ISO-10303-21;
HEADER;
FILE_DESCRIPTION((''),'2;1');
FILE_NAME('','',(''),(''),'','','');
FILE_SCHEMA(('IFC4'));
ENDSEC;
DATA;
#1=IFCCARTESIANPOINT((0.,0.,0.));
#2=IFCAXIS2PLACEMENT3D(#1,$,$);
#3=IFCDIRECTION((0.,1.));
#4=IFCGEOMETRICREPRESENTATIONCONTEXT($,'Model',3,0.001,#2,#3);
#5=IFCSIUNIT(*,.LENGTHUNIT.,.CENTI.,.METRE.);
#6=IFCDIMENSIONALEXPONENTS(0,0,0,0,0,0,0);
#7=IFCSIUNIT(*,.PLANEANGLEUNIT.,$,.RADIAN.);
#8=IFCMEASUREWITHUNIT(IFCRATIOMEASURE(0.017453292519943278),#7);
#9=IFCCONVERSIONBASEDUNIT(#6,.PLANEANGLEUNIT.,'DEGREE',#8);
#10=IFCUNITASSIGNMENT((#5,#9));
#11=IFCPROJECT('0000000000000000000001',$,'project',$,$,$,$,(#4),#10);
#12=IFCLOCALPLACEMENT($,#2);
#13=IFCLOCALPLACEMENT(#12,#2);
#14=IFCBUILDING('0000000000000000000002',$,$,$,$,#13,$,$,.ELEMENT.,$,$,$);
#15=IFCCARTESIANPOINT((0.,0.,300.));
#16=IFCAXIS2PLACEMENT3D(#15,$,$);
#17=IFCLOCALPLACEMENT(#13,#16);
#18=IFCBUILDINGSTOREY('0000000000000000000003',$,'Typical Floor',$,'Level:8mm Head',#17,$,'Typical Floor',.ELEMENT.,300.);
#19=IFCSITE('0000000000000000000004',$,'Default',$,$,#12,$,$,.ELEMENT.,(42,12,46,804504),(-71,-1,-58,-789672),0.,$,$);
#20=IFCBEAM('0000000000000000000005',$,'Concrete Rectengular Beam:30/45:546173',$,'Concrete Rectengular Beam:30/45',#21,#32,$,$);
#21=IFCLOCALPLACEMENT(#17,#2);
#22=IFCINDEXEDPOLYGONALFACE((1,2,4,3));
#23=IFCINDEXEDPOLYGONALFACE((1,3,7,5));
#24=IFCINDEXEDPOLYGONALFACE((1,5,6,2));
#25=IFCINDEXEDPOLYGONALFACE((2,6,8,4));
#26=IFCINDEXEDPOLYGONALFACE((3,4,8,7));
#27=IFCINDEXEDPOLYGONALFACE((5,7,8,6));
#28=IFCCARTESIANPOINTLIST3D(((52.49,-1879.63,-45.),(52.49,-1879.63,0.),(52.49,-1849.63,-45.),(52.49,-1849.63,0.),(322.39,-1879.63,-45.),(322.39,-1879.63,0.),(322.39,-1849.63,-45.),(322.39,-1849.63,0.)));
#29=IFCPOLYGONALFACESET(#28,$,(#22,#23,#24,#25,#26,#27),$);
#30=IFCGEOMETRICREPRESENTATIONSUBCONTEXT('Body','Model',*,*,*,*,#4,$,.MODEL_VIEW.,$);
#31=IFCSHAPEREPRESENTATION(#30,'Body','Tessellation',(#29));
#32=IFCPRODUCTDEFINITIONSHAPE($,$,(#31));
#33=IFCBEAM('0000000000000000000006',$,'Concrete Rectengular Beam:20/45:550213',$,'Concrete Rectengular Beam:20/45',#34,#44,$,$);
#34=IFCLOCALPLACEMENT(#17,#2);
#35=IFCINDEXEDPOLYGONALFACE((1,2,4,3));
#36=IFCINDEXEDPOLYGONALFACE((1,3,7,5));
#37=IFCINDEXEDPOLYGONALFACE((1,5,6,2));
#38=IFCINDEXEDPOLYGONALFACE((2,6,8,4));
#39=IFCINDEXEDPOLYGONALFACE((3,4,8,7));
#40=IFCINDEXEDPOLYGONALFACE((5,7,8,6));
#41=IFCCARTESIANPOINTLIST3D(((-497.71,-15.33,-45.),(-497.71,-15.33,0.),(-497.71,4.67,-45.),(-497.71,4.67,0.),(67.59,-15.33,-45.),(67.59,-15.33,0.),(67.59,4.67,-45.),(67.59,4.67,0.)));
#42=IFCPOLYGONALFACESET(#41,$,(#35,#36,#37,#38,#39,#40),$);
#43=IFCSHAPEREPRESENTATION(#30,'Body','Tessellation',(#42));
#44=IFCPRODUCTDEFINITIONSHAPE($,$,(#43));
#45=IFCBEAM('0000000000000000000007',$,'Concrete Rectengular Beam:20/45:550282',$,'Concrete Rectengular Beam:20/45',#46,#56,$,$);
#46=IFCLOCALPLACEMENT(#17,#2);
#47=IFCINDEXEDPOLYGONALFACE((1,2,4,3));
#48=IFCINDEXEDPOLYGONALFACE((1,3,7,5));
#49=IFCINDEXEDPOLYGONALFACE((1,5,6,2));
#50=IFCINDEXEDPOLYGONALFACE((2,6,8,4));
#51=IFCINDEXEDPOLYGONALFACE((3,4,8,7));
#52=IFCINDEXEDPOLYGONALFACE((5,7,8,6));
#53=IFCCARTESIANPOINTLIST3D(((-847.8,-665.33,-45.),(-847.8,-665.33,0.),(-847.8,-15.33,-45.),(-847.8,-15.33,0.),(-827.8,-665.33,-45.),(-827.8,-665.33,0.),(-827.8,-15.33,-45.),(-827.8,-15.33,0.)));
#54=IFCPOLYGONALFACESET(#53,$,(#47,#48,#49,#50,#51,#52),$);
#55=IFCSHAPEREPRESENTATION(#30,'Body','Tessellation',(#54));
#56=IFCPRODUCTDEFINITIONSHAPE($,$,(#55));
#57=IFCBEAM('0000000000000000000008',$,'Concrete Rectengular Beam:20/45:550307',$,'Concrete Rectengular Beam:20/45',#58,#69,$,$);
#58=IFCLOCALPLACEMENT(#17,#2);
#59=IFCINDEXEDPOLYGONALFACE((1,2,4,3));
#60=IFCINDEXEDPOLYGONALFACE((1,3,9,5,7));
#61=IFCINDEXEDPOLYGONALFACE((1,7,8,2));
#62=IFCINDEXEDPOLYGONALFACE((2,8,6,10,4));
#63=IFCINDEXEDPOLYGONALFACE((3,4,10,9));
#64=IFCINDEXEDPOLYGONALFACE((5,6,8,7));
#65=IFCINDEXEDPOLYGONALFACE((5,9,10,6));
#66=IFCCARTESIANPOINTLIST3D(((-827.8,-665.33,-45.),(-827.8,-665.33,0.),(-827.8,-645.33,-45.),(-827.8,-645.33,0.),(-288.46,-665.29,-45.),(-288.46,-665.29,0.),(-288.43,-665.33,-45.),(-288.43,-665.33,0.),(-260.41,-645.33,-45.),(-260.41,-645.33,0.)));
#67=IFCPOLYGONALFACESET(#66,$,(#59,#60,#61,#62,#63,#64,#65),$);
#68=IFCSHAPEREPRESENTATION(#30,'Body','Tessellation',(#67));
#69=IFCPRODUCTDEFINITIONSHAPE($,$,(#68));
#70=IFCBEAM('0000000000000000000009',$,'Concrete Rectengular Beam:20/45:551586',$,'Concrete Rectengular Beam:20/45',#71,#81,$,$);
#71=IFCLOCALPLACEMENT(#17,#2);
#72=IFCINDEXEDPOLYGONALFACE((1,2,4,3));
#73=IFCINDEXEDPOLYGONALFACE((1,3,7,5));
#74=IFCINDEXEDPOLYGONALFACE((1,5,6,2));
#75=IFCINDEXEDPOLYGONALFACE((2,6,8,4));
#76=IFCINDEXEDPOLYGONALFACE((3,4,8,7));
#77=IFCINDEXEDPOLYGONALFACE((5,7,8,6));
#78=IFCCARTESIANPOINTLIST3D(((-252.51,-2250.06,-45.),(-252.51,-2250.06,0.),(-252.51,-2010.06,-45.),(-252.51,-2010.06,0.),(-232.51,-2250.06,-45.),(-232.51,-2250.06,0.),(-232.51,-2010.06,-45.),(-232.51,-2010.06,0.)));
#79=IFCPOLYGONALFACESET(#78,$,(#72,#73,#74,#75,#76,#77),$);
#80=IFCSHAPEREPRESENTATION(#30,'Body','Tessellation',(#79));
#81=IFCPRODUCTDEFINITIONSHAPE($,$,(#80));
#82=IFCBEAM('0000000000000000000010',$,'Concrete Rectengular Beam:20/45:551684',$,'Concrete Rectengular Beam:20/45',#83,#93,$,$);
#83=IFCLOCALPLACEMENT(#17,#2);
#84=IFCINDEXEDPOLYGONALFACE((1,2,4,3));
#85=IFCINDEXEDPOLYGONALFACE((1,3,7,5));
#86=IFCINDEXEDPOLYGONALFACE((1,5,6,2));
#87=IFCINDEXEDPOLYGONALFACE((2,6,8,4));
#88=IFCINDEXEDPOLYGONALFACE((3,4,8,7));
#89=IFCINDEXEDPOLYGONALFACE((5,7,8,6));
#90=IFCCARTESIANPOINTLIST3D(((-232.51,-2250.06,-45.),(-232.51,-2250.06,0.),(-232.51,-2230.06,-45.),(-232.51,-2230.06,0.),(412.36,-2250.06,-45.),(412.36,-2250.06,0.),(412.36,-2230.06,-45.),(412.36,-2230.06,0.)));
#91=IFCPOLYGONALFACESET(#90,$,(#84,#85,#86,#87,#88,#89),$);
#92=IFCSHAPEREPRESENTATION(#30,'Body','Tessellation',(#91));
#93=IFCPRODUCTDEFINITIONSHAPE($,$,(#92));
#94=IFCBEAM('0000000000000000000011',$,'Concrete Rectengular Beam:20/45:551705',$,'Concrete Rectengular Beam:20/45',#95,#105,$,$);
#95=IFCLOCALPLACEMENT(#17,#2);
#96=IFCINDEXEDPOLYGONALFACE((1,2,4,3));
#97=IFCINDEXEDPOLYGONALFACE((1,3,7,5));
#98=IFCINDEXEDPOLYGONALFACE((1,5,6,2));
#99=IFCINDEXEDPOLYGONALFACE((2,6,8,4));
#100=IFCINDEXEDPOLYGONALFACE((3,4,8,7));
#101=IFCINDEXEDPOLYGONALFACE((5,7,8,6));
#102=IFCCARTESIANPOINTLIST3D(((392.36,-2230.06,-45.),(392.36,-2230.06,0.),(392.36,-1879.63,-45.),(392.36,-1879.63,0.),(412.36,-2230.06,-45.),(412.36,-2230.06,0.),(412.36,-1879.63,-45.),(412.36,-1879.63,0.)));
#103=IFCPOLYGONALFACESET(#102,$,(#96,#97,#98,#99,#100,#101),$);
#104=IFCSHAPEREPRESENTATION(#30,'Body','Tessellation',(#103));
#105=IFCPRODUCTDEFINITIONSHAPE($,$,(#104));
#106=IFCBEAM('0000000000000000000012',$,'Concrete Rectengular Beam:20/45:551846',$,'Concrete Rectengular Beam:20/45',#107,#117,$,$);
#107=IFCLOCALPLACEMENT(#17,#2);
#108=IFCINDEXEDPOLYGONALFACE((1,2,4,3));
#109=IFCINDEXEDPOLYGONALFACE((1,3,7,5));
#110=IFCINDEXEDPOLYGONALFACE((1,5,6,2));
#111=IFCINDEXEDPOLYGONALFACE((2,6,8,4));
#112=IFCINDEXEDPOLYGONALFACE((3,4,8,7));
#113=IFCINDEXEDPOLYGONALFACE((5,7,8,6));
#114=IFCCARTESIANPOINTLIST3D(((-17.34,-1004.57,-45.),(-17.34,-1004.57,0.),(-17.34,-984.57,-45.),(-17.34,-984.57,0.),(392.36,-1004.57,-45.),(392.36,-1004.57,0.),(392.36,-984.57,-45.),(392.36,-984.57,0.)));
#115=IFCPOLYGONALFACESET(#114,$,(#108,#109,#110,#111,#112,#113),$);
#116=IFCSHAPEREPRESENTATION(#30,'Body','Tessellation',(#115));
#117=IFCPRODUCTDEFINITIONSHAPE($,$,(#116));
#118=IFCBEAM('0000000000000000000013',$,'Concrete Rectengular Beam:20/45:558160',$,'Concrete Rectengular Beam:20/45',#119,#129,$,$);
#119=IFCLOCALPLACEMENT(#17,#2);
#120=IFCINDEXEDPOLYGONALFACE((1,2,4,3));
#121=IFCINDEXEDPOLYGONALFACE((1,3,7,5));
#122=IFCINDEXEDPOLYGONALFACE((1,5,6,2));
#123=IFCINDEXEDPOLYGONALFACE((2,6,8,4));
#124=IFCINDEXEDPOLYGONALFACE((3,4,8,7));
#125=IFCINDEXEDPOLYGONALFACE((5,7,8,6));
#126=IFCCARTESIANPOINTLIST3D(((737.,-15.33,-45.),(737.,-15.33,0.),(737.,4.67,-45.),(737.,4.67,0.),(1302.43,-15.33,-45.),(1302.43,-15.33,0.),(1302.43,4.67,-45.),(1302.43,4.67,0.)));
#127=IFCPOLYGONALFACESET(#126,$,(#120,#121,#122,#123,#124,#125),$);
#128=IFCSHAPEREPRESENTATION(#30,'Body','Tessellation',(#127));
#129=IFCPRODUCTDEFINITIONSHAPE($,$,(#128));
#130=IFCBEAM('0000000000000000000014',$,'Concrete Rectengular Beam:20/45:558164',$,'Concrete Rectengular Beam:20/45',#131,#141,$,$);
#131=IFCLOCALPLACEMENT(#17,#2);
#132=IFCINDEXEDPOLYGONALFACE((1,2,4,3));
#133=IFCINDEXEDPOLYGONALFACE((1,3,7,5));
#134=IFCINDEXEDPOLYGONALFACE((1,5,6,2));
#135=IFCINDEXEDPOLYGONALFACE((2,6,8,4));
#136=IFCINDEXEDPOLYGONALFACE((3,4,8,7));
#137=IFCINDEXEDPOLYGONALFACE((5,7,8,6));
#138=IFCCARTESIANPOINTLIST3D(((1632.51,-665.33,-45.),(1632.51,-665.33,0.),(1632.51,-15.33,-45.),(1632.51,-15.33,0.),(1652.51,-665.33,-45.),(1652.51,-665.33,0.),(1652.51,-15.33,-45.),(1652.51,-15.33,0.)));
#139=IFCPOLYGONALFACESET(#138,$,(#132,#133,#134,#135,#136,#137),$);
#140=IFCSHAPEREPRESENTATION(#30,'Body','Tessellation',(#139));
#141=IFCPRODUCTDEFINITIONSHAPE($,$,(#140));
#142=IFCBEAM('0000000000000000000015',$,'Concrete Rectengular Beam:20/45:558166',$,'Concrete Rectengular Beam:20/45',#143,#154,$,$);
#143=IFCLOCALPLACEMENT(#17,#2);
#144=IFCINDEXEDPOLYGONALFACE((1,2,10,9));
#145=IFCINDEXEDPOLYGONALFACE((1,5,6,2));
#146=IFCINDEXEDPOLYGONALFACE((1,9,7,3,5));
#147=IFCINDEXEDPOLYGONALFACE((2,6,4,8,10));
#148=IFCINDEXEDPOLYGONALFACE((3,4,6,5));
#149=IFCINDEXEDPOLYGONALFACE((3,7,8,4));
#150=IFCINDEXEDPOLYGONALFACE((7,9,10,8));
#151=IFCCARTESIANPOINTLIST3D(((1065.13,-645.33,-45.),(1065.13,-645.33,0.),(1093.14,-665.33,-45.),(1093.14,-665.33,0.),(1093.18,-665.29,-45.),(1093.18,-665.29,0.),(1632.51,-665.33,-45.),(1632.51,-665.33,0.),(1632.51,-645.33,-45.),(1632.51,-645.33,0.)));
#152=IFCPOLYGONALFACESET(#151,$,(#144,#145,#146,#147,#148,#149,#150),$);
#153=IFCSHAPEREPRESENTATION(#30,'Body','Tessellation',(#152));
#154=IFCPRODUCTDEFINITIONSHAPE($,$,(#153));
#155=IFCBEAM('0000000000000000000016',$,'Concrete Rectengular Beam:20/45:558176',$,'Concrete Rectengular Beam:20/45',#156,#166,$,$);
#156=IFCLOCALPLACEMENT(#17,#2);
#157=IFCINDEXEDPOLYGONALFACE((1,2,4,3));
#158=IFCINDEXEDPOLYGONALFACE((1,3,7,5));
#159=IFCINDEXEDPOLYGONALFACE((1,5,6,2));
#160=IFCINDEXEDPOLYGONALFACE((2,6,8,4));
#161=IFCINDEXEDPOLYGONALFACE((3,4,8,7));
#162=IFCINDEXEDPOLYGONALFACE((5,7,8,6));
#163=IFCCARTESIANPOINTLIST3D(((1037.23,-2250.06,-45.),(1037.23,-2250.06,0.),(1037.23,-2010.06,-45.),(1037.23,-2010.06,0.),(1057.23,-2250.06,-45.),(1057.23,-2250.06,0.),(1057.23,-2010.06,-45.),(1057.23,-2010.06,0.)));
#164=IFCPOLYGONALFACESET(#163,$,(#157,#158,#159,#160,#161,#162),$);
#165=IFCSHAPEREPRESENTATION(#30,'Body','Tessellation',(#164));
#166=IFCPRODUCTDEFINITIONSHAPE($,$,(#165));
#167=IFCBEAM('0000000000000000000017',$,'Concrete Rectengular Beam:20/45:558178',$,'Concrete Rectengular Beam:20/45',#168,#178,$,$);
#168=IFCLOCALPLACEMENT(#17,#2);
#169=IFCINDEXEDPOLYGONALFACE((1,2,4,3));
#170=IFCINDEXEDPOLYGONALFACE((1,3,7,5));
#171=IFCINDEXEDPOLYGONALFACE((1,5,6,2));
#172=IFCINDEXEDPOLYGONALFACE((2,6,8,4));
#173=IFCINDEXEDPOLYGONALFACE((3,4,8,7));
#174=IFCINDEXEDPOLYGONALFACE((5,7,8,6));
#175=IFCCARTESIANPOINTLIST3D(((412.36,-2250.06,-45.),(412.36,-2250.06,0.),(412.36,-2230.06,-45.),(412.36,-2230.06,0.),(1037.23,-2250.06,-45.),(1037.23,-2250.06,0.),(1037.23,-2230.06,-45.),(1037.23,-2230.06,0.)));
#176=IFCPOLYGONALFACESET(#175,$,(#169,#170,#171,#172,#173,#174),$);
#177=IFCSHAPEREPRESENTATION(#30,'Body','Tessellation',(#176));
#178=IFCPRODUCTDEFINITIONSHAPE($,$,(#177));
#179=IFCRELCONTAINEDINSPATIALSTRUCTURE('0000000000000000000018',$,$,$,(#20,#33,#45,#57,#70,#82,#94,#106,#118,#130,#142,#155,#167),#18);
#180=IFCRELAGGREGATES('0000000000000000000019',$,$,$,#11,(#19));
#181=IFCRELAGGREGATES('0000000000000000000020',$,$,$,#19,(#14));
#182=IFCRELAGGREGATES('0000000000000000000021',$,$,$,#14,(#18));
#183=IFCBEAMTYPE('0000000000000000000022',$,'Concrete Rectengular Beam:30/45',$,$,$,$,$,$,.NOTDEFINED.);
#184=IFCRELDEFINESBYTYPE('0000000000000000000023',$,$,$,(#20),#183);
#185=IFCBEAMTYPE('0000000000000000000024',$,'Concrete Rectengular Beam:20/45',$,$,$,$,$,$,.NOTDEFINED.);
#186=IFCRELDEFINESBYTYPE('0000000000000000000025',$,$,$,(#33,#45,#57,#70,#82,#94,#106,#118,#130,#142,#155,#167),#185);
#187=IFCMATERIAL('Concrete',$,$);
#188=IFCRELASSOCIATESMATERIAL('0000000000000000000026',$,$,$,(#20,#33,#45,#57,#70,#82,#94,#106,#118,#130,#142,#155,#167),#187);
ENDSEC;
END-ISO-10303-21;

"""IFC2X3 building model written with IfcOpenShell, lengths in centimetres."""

from ifc_helpers import new_model, entity, si_unit, converted_unit, direction, frame, frame_2d, origin, place, context, subcontext, project, spatial, polyline, rectangle, extrude, clip, bounded_halfspace, material, type_object, element, save


model = new_model("IFC2X3")

# Units and contexts
model_context = context("Model", 3, precision=0.001, world=origin(), true_north=direction((0.0, 1.0)))
body_context = subcontext(model_context, "Body", "Model", "MODEL_VIEW")
ifc_project = project(units=[si_unit("LENGTHUNIT", "METRE", prefix="CENTI"), converted_unit("PLANEANGLEUNIT", "DEGREE", entity("IfcRatioMeasure", 0.017453292519943278), si_unit("PLANEANGLEUNIT", "RADIAN"), dimensions=[0, 0, 0, 0, 0, 0, 0])], contexts=[model_context])

# Site, building, storey
site_placement = place(None, origin())
site = spatial("IfcSite", under=ifc_project, at=site_placement, Name="Default", CompositionType="ELEMENT", RefLatitude=(42, 12, 46, 804504), RefLongitude=(-71, -1, -58, -789672), RefElevation=0.0)
building_placement = place(site_placement, origin())
building = spatial("IfcBuilding", under=site, at=building_placement, CompositionType="ELEMENT")
storey_placement = place(building_placement, frame((0.0, 0.0, 300.0)))
storey = spatial("IfcBuildingStorey", under=building, at=storey_placement, Name="Typical Floor", ObjectType="Level:8mm Head", LongName="Typical Floor", CompositionType="ELEMENT", Elevation=300.0)

# Beams
ifc_material = material(Name="Concrete")
beam_type_1 = type_object("IfcBeamType", Name="Concrete Rectengular Beam:30/45", PredefinedType="NOTDEFINED")
beam_1_placement = place(storey_placement, frame((322.39, -1864.63, 0.0), z_axis=(0.0, 0.0, 1.0), x_axis=(-1.0, 0.0, 0.0)))
element("IfcBeam", 1, at=beam_1_placement, inside=storey, type_object=beam_type_1, material=ifc_material, Name="Concrete Rectengular Beam:30/45:546173", ObjectType="Concrete Rectengular Beam:30/45", context=body_context, shape_type="SweptSolid", body=[
    extrude(rectangle(XDim=45.0, YDim=30.0, at=frame_2d((0.0, 0.0), x_axis=(1.0, 0.0))), frame((0.0, 0.0, -22.5), z_axis=(1.0, 0.0, 0.0), x_axis=(0.0, 0.0, -1.0)), (0.0, 0.0, 1.0), 269.9),
])
beam_type_2 = type_object("IfcBeamType", Name="Concrete Rectengular Beam:20/45", PredefinedType="NOTDEFINED")
beam_2_placement = place(storey_placement, frame((-507.71, -5.33, 0.0)))
element("IfcBeam", 2, at=beam_2_placement, inside=storey, type_object=beam_type_2, material=ifc_material, Name="Concrete Rectengular Beam:20/45:550213", ObjectType="Concrete Rectengular Beam:20/45", context=body_context, shape_type="SweptSolid", body=[
    extrude(rectangle(XDim=45.0, YDim=20.0, at=frame_2d((0.0, 0.0), x_axis=(1.0, 0.0))), frame((10.0, 0.0, -22.5), z_axis=(1.0, 0.0, 0.0), x_axis=(0.0, 0.0, -1.0)), (0.0, 0.0, 1.0), 565.3),
])
beam_3_placement = place(storey_placement, frame((-837.8, -5.33, 0.0), z_axis=(0.0, 0.0, 1.0), x_axis=(0.0, -1.0, 0.0)))
element("IfcBeam", 3, at=beam_3_placement, inside=storey, type_object=beam_type_2, material=ifc_material, Name="Concrete Rectengular Beam:20/45:550282", ObjectType="Concrete Rectengular Beam:20/45", context=body_context, shape_type="SweptSolid", body=[
    extrude(rectangle(XDim=45.0, YDim=20.0, at=frame_2d((0.0, 0.0), x_axis=(1.0, 0.0))), frame((10.0, 0.0, -22.5), z_axis=(1.0, 0.0, 0.0), x_axis=(0.0, 0.0, -1.0)), (0.0, 0.0, 1.0), 650.0),
])
beam_4_placement = place(storey_placement, frame((-837.8, -655.33, 0.0)))
element("IfcBeam", 4, at=beam_4_placement, inside=storey, type_object=beam_type_2, material=ifc_material, Name="Concrete Rectengular Beam:20/45:550307", ObjectType="Concrete Rectengular Beam:20/45", context=body_context, shape_type="SweptSolid", body=[
    clip(clip(extrude(rectangle(XDim=45.0, YDim=20.0, at=frame_2d((0.0, 0.0), x_axis=(1.0, 0.0))), frame((10.0, 0.0, -22.5), z_axis=(1.0, 0.0, 0.0), x_axis=(0.0, 0.0, -1.0)), (0.0, 0.0, 1.0), 567.38), bounded_halfspace(frame((577.9, 10.37, -300.0), z_axis=(0.579755, -0.814791, 0.0), x_axis=(-0.814791, -0.579755, 0.0)), False, frame((10.0, 0.0, -22.5), z_axis=(1.0, 0.0, 0.0), x_axis=(0.0, 0.0, -1.0)), polyline([(-22.5, -9.96), (22.5, -9.96), (22.5, 10.0), (-22.5, 10.0), (-22.5, -9.96)]))), bounded_halfspace(frame((691.72, -210.34, -300.0), z_axis=(0.81518, 0.579207, 0.0), x_axis=(0.579207, -0.81518, 0.0)), False, frame((10.0, 0.0, -22.5), z_axis=(1.0, 0.0, 0.0), x_axis=(0.0, 0.0, -1.0)), polyline([(22.5, -9.96), (-22.5, -9.96), (-22.5, -10.0), (22.5, -10.0), (22.5, -9.96)]))),
])
beam_5_placement = place(storey_placement, frame((-242.51, -2000.06, 0.0), z_axis=(0.0, 0.0, 1.0), x_axis=(0.0, -1.0, 0.0)))
element("IfcBeam", 5, at=beam_5_placement, inside=storey, type_object=beam_type_2, material=ifc_material, Name="Concrete Rectengular Beam:20/45:551586", ObjectType="Concrete Rectengular Beam:20/45", context=body_context, shape_type="SweptSolid", body=[
    extrude(rectangle(XDim=45.0, YDim=20.0, at=frame_2d((0.0, 0.0), x_axis=(1.0, 0.0))), frame((10.0, 0.0, -22.5), z_axis=(1.0, 0.0, 0.0), x_axis=(0.0, 0.0, -1.0)), (0.0, 0.0, 1.0), 240.0),
])
beam_6_placement = place(storey_placement, frame((-242.51, -2240.06, 0.0)))
element("IfcBeam", 6, at=beam_6_placement, inside=storey, type_object=beam_type_2, material=ifc_material, Name="Concrete Rectengular Beam:20/45:551684", ObjectType="Concrete Rectengular Beam:20/45", context=body_context, shape_type="SweptSolid", body=[
    extrude(rectangle(XDim=45.0, YDim=20.0, at=frame_2d((0.0, 0.0), x_axis=(1.0, 0.0))), frame((10.0, 0.0, -22.5), z_axis=(1.0, 0.0, 0.0), x_axis=(0.0, 0.0, -1.0)), (0.0, 0.0, 1.0), 644.87),
])
beam_7_placement = place(storey_placement, frame((402.36, -2240.06, 0.0), z_axis=(0.0, 0.0, 1.0), x_axis=(0.0, 1.0, 0.0)))
element("IfcBeam", 7, at=beam_7_placement, inside=storey, type_object=beam_type_2, material=ifc_material, Name="Concrete Rectengular Beam:20/45:551705", ObjectType="Concrete Rectengular Beam:20/45", context=body_context, shape_type="SweptSolid", body=[
    extrude(rectangle(XDim=45.0, YDim=20.0, at=frame_2d((0.0, 0.0), x_axis=(1.0, 0.0))), frame((10.0, 0.0, -22.5), z_axis=(1.0, 0.0, 0.0), x_axis=(0.0, 0.0, -1.0)), (0.0, 0.0, 1.0), 350.43),
])
beam_8_placement = place(storey_placement, frame((-27.34, -994.57, 0.0)))
element("IfcBeam", 8, at=beam_8_placement, inside=storey, type_object=beam_type_2, material=ifc_material, Name="Concrete Rectengular Beam:20/45:551846", ObjectType="Concrete Rectengular Beam:20/45", context=body_context, shape_type="SweptSolid", body=[
    extrude(rectangle(XDim=45.0, YDim=20.0, at=frame_2d((0.0, 0.0), x_axis=(1.0, 0.0))), frame((10.0, 0.0, -22.5), z_axis=(1.0, 0.0, 0.0), x_axis=(0.0, 0.0, -1.0)), (0.0, 0.0, 1.0), 409.7),
])
beam_9_placement = place(storey_placement, frame((1312.43, -5.33, 0.0), z_axis=(0.0, 0.0, 1.0), x_axis=(-1.0, 0.0, 0.0)))
element("IfcBeam", 9, at=beam_9_placement, inside=storey, type_object=beam_type_2, material=ifc_material, Name="Concrete Rectengular Beam:20/45:558160", ObjectType="Concrete Rectengular Beam:20/45", context=body_context, shape_type="SweptSolid", body=[
    extrude(rectangle(XDim=45.0, YDim=20.0, at=frame_2d((0.0, 0.0), x_axis=(1.0, 0.0))), frame((10.0, 0.0, -22.5), z_axis=(1.0, 0.0, 0.0), x_axis=(0.0, 0.0, -1.0)), (0.0, 0.0, 1.0), 565.43),
])
beam_10_placement = place(storey_placement, frame((1642.51, -5.33, 0.0), z_axis=(0.0, 0.0, 1.0), x_axis=(0.0, -1.0, 0.0)))
element("IfcBeam", 10, at=beam_10_placement, inside=storey, type_object=beam_type_2, material=ifc_material, Name="Concrete Rectengular Beam:20/45:558164", ObjectType="Concrete Rectengular Beam:20/45", context=body_context, shape_type="SweptSolid", body=[
    extrude(rectangle(XDim=45.0, YDim=20.0, at=frame_2d((0.0, 0.0), x_axis=(1.0, 0.0))), frame((10.0, 0.0, -22.5), z_axis=(1.0, 0.0, 0.0), x_axis=(0.0, 0.0, -1.0)), (0.0, 0.0, 1.0), 650.0),
])
beam_11_placement = place(storey_placement, frame((1642.51, -655.33, 0.0), z_axis=(0.0, 0.0, 1.0), x_axis=(-1.0, 0.0, 0.0)))
element("IfcBeam", 11, at=beam_11_placement, inside=storey, type_object=beam_type_2, material=ifc_material, Name="Concrete Rectengular Beam:20/45:558166", ObjectType="Concrete Rectengular Beam:20/45", context=body_context, shape_type="SweptSolid", body=[
    clip(clip(extrude(rectangle(XDim=45.0, YDim=20.0, at=frame_2d((0.0, 0.0), x_axis=(1.0, 0.0))), frame((10.0, 0.0, -22.5), z_axis=(1.0, 0.0, 0.0), x_axis=(0.0, 0.0, -1.0)), (0.0, 0.0, 1.0), 567.38), bounded_halfspace(frame((691.72, 210.34, -300.0), z_axis=(0.81518, -0.579207, 0.0), x_axis=(-0.579207, -0.81518, 0.0)), False, frame((10.0, 0.0, -22.5), z_axis=(1.0, 0.0, 0.0), x_axis=(0.0, 0.0, -1.0)), polyline([(-22.5, 10.0), (-22.5, 9.96), (22.5, 9.96), (22.5, 10.0), (-22.5, 10.0)]))), bounded_halfspace(frame((577.9, -10.37, -300.0), z_axis=(0.579755, 0.814791, 0.0), x_axis=(0.814791, -0.579755, 0.0)), False, frame((10.0, 0.0, -22.5), z_axis=(1.0, 0.0, 0.0), x_axis=(0.0, 0.0, -1.0)), polyline([(-22.5, 9.96), (-22.5, -10.0), (-2.5, -10.0), (22.5, -10.0), (22.5, 9.96), (-22.5, 9.96)]))),
])
beam_12_placement = place(storey_placement, frame((1047.23, -2000.06, 0.0), z_axis=(0.0, 0.0, 1.0), x_axis=(0.0, -1.0, 0.0)))
element("IfcBeam", 12, at=beam_12_placement, inside=storey, type_object=beam_type_2, material=ifc_material, Name="Concrete Rectengular Beam:20/45:558176", ObjectType="Concrete Rectengular Beam:20/45", context=body_context, shape_type="SweptSolid", body=[
    extrude(rectangle(XDim=45.0, YDim=20.0, at=frame_2d((0.0, 0.0), x_axis=(1.0, 0.0))), frame((10.0, 0.0, -22.5), z_axis=(1.0, 0.0, 0.0), x_axis=(0.0, 0.0, -1.0)), (0.0, 0.0, 1.0), 240.0),
])
beam_13_placement = place(storey_placement, frame((1047.23, -2240.06, 0.0), z_axis=(0.0, 0.0, 1.0), x_axis=(-1.0, 0.0, 0.0)))
element("IfcBeam", 13, at=beam_13_placement, inside=storey, type_object=beam_type_2, material=ifc_material, Name="Concrete Rectengular Beam:20/45:558178", ObjectType="Concrete Rectengular Beam:20/45", context=body_context, shape_type="SweptSolid", body=[
    extrude(rectangle(XDim=45.0, YDim=20.0, at=frame_2d((0.0, 0.0), x_axis=(1.0, 0.0))), frame((10.0, 0.0, -22.5), z_axis=(1.0, 0.0, 0.0), x_axis=(0.0, 0.0, -1.0)), (0.0, 0.0, 1.0), 624.87),
])

save(model, "model.ifc")
